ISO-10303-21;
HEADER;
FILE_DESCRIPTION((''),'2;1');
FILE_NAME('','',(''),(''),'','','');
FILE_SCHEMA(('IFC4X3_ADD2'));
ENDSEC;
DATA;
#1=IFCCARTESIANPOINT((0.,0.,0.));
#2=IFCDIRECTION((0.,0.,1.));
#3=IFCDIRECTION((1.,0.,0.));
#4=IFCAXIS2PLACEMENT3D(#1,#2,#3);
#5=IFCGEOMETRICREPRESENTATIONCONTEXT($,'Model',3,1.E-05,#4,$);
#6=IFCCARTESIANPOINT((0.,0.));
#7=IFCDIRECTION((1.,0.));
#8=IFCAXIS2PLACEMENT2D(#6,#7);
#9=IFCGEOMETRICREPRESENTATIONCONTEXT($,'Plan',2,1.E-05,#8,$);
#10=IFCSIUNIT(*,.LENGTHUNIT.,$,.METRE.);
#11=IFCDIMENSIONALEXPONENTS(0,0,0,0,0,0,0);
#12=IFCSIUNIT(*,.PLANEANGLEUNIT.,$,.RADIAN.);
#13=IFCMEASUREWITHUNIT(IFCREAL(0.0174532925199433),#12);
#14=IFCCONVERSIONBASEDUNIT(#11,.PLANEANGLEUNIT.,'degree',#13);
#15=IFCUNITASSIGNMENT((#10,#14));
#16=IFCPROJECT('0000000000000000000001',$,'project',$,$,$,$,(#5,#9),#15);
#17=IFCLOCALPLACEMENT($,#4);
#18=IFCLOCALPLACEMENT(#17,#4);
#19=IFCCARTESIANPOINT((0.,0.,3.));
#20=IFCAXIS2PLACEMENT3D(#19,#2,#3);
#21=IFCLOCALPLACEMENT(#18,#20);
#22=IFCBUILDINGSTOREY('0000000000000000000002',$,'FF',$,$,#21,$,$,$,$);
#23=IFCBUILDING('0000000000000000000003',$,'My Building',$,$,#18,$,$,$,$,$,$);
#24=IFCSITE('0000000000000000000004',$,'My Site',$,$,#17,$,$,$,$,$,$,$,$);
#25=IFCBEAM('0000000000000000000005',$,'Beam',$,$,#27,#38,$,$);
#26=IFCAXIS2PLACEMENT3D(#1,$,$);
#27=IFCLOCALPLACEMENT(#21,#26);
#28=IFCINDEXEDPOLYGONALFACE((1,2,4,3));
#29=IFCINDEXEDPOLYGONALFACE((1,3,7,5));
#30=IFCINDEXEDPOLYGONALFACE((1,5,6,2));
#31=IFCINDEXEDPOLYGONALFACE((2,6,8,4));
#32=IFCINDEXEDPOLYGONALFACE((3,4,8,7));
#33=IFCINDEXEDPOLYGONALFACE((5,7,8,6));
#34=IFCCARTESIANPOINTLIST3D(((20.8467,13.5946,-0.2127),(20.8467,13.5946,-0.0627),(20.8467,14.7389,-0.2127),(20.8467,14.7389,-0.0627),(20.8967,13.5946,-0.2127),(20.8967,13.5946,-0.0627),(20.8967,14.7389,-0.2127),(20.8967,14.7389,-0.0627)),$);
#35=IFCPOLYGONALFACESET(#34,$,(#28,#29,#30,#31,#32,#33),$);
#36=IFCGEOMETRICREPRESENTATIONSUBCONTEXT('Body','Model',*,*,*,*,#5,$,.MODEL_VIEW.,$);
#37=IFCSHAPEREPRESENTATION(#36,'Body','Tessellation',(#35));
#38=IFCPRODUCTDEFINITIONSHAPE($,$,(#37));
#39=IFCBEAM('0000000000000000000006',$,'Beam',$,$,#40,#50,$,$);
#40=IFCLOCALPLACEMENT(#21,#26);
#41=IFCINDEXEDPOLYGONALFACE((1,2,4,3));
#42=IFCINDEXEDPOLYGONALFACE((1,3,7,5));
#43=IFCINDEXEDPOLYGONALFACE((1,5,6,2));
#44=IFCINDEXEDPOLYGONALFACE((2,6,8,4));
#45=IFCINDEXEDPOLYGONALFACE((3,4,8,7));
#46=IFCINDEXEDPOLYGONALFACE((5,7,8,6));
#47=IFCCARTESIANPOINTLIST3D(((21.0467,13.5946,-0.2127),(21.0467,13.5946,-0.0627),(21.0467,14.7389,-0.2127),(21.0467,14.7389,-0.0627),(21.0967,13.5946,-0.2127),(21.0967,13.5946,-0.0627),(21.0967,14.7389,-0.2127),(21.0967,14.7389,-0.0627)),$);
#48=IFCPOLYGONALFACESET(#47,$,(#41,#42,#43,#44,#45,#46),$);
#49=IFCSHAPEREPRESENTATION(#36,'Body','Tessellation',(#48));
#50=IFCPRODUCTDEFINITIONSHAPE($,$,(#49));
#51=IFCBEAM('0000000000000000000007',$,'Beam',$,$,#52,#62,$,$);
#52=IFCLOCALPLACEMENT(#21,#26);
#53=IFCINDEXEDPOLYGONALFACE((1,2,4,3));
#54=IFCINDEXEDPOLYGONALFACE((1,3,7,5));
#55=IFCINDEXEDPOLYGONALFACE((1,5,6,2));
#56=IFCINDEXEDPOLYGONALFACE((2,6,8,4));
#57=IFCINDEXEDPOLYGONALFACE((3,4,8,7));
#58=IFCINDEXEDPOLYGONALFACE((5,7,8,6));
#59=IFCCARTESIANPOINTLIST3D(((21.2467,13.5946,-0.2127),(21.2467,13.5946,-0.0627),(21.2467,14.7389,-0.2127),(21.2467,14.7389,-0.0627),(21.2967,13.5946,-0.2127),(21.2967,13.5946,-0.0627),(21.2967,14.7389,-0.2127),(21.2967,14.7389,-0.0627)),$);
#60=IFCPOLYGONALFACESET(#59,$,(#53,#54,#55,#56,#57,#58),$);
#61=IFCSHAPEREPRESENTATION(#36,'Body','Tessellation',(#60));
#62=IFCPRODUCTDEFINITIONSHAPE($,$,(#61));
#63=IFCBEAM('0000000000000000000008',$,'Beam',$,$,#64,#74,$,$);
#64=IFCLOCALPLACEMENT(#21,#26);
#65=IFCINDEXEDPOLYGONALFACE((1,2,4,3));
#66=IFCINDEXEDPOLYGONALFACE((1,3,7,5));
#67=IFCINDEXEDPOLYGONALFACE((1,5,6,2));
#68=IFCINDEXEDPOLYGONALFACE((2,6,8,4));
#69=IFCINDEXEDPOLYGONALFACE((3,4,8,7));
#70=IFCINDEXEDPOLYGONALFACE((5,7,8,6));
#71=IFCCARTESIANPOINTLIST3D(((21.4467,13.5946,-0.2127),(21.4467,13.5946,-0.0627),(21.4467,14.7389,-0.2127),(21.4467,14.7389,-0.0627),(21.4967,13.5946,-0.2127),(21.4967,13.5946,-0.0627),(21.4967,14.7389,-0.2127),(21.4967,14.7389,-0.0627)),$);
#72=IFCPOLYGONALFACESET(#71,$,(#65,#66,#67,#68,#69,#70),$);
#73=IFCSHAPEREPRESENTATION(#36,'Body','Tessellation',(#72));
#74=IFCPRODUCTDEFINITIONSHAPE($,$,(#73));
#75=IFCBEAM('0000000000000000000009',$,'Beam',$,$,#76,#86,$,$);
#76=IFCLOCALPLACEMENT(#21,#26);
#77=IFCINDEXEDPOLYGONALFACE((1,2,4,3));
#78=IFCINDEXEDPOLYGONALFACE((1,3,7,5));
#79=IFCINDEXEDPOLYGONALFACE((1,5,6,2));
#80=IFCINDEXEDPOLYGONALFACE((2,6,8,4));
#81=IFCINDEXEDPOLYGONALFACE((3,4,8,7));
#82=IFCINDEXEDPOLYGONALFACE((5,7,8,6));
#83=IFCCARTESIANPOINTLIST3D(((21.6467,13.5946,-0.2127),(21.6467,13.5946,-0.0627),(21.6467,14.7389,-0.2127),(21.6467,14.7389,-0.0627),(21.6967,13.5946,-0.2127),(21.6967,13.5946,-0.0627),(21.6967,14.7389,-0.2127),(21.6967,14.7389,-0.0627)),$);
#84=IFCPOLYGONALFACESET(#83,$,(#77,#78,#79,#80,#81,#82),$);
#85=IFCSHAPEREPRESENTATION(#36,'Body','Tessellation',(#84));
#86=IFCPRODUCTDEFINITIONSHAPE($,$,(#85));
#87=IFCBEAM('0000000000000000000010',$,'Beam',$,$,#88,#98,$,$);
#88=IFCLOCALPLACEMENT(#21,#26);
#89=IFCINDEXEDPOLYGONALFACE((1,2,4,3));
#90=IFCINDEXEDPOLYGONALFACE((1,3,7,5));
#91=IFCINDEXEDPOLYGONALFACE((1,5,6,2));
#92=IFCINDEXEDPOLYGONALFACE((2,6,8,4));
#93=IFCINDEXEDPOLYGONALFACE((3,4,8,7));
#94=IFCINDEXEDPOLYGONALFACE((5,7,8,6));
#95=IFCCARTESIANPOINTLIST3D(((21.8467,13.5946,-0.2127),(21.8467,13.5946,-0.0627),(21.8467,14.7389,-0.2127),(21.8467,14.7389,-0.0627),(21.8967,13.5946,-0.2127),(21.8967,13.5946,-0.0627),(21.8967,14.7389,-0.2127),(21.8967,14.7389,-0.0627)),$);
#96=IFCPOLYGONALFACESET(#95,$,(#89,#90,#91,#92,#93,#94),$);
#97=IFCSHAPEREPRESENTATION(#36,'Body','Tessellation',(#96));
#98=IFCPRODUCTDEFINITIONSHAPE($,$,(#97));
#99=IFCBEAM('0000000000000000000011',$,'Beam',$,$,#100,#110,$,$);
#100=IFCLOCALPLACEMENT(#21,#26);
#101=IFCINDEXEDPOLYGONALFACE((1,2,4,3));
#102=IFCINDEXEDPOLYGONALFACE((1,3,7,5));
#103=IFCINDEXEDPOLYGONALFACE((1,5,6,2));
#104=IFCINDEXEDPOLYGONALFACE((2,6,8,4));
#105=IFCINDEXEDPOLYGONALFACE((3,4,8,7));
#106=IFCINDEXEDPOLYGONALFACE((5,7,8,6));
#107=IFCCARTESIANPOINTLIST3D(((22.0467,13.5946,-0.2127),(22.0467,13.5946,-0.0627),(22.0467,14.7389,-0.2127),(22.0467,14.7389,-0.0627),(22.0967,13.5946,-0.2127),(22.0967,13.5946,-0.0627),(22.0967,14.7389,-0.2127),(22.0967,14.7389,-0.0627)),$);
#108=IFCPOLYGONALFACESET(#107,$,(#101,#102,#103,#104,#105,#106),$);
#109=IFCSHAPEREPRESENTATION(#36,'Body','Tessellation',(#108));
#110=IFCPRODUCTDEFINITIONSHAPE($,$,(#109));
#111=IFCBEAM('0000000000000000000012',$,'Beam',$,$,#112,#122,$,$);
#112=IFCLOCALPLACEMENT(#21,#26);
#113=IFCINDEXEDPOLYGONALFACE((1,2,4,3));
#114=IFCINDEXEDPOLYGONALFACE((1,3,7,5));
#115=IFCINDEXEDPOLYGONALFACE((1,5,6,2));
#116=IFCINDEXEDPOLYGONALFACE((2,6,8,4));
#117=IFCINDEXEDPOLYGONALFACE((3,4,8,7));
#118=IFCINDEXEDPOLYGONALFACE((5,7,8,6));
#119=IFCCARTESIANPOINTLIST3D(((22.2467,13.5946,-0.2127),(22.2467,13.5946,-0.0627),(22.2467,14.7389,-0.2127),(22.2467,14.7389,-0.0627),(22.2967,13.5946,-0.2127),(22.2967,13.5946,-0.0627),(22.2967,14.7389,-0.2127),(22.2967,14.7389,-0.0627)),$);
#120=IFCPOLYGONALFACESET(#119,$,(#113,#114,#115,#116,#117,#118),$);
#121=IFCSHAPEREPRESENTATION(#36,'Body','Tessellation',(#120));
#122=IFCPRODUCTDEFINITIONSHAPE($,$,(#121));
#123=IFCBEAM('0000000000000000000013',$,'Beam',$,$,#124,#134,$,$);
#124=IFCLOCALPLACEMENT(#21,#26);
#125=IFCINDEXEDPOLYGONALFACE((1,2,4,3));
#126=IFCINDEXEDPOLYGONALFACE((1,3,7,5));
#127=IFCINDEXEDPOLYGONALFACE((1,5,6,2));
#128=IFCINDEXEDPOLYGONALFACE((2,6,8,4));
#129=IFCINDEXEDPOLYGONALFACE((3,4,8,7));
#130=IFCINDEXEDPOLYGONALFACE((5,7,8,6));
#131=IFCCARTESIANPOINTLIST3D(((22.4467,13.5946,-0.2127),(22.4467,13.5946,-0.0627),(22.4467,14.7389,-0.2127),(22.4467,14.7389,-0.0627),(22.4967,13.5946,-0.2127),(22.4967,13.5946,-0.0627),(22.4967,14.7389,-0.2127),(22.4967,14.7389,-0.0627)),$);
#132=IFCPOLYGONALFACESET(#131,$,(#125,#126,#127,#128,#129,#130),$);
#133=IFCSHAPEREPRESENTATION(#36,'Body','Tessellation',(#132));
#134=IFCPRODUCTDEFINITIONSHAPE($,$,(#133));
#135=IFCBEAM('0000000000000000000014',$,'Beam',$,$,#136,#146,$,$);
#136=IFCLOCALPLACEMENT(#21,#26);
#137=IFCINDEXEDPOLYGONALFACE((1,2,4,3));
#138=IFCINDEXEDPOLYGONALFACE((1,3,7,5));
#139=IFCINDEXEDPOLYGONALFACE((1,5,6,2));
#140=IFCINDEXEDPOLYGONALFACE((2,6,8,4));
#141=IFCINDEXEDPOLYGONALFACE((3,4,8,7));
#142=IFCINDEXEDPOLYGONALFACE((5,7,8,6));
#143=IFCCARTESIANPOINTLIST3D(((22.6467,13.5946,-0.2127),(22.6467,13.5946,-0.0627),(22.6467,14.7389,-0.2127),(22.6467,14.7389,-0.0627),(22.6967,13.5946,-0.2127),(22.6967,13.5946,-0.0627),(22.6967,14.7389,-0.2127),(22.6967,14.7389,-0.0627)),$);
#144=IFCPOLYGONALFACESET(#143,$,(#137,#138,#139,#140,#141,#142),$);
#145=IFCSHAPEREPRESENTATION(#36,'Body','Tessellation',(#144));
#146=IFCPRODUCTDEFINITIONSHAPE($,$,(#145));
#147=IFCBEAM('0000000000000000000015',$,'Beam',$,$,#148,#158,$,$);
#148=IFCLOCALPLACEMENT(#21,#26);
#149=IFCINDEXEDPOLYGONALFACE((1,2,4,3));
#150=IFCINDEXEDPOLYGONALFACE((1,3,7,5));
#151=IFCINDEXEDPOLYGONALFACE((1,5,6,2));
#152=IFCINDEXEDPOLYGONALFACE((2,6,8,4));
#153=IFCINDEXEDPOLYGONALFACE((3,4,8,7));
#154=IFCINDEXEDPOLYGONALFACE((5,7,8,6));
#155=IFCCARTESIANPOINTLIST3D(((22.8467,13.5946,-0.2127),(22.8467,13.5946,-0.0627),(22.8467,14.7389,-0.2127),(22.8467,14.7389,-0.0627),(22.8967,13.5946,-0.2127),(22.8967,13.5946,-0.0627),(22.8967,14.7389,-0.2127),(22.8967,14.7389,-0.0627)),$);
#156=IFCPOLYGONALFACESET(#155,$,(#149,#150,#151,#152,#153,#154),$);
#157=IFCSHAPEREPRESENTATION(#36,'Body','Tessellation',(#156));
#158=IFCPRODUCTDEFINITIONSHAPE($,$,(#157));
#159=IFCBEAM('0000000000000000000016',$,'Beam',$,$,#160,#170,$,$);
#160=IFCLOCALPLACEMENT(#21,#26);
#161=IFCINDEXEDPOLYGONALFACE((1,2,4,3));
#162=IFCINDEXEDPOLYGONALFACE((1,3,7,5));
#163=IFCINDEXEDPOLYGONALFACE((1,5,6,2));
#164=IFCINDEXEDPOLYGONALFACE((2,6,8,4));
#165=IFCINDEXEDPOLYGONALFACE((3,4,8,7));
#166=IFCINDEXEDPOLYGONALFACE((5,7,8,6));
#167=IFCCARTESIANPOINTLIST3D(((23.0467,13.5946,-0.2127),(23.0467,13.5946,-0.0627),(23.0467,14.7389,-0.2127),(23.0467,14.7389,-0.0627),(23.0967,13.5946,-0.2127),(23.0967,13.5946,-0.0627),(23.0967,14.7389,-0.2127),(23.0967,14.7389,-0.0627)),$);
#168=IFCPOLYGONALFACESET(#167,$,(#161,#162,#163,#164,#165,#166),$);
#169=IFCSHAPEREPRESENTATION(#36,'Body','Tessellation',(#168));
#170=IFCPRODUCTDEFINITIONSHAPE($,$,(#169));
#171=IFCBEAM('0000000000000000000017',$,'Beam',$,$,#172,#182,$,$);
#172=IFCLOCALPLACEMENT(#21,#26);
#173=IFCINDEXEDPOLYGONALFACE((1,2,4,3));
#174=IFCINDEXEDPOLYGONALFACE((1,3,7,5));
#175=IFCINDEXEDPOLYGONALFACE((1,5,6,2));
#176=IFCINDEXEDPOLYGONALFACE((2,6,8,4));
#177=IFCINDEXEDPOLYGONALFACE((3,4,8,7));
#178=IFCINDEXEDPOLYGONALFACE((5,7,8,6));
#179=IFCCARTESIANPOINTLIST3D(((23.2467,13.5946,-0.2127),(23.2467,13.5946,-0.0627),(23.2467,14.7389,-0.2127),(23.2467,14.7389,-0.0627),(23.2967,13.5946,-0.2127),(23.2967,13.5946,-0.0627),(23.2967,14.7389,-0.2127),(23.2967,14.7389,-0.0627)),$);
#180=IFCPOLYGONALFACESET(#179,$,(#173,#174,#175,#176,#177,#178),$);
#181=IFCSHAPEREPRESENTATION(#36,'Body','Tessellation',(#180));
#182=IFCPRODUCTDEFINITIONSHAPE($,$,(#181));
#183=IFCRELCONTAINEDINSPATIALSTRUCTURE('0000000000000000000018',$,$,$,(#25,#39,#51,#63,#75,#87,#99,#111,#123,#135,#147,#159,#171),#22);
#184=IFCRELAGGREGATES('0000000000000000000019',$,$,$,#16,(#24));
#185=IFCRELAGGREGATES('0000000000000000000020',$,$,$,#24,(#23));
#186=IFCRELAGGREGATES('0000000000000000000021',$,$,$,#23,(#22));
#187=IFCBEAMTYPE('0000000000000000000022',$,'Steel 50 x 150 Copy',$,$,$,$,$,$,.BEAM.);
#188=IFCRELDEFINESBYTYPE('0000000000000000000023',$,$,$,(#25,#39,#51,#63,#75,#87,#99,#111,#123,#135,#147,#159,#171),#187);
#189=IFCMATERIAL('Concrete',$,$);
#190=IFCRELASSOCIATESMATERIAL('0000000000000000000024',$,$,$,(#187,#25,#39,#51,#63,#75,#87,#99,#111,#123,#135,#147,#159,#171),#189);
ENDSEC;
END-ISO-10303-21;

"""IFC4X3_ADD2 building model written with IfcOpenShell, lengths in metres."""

from ifc_helpers import new_model, entity, si_unit, converted_unit, frame, origin_with_axes, origin_2d_with_axis, place, context, subcontext, project, spatial, rectangle, extrude, material, material_profile, profile_set, profile_usage, type_object, element, save


model = new_model("IFC4X3_ADD2")

# Units and contexts
model_context = context("Model", 3, precision=1e-05, world=origin_with_axes())
plan_context = context("Plan", 2, precision=1e-05, world=origin_2d_with_axis())
body_context = subcontext(model_context, "Body", "Model", "MODEL_VIEW")
ifc_project = project(units=[si_unit("LENGTHUNIT", "METRE"), converted_unit("PLANEANGLEUNIT", "degree", entity("IfcReal", 0.0174532925199433), si_unit("PLANEANGLEUNIT", "RADIAN"), dimensions=[0, 0, 0, 0, 0, 0, 0])], contexts=[model_context, plan_context])

# Site, building, storey
site_placement = place(None, origin_with_axes())
site = spatial("IfcSite", under=ifc_project, at=site_placement, Name="My Site")
building_placement = place(site_placement, origin_with_axes())
building = spatial("IfcBuilding", under=site, at=building_placement, Name="My Building")
storey_placement = place(building_placement, frame((0.0, 0.0, 3.0), z_axis=(0.0, 0.0, 1.0), x_axis=(1.0, 0.0, 0.0)))
storey = spatial("IfcBuildingStorey", under=building, at=storey_placement, Name="FF")

# Beams
ifc_material = material(Name="Concrete")
ifc_material_profile_1 = material_profile(ifc_material, rectangle(XDim=0.05, YDim=0.15))
ifc_profile_set_1 = profile_set([ifc_material_profile_1])
beam_type_1 = type_object("IfcBeamType", Name="Steel 50 x 150 Copy", PredefinedType="BEAM", material=ifc_profile_set_1)
ifc_profile_usage_1 = profile_usage(ifc_profile_set_1)
beam_1_placement = place(storey_placement, frame((20.8717, 14.7389, -0.1377), z_axis=(0.0, -1.0, 0.0), x_axis=(1.0, 0.0, 0.0)))
element("IfcBeam", 1, at=beam_1_placement, inside=storey, type_object=beam_type_1, material=ifc_profile_usage_1, Name="Beam", context=body_context, shape_type="SweptSolid", body=[
    extrude(rectangle(XDim=0.05, YDim=0.15), origin_with_axes(), (0.0, 0.0, 1.0), 1.1444),
])
ifc_profile_usage_2 = profile_usage(ifc_profile_set_1)
beam_2_placement = place(storey_placement, frame((21.0717, 14.7389, -0.1377), z_axis=(0.0, -1.0, 0.0), x_axis=(1.0, 0.0, 0.0)))
element("IfcBeam", 2, at=beam_2_placement, inside=storey, type_object=beam_type_1, material=ifc_profile_usage_2, Name="Beam", context=body_context, shape_type="SweptSolid", body=[
    extrude(rectangle(XDim=0.05, YDim=0.15), origin_with_axes(), (0.0, 0.0, 1.0), 1.1444),
])
ifc_profile_usage_3 = profile_usage(ifc_profile_set_1)
beam_3_placement = place(storey_placement, frame((21.2717, 14.7389, -0.1377), z_axis=(0.0, -1.0, 0.0), x_axis=(1.0, 0.0, 0.0)))
element("IfcBeam", 3, at=beam_3_placement, inside=storey, type_object=beam_type_1, material=ifc_profile_usage_3, Name="Beam", context=body_context, shape_type="SweptSolid", body=[
    extrude(rectangle(XDim=0.05, YDim=0.15), origin_with_axes(), (0.0, 0.0, 1.0), 1.1444),
])
ifc_profile_usage_4 = profile_usage(ifc_profile_set_1)
beam_4_placement = place(storey_placement, frame((21.4717, 14.7389, -0.1377), z_axis=(0.0, -1.0, 0.0), x_axis=(1.0, 0.0, 0.0)))
element("IfcBeam", 4, at=beam_4_placement, inside=storey, type_object=beam_type_1, material=ifc_profile_usage_4, Name="Beam", context=body_context, shape_type="SweptSolid", body=[
    extrude(rectangle(XDim=0.05, YDim=0.15), origin_with_axes(), (0.0, 0.0, 1.0), 1.1444),
])
ifc_profile_usage_5 = profile_usage(ifc_profile_set_1)
beam_5_placement = place(storey_placement, frame((21.6717, 14.7389, -0.1377), z_axis=(0.0, -1.0, 0.0), x_axis=(1.0, 0.0, 0.0)))
element("IfcBeam", 5, at=beam_5_placement, inside=storey, type_object=beam_type_1, material=ifc_profile_usage_5, Name="Beam", context=body_context, shape_type="SweptSolid", body=[
    extrude(rectangle(XDim=0.05, YDim=0.15), origin_with_axes(), (0.0, 0.0, 1.0), 1.1444),
])
ifc_profile_usage_6 = profile_usage(ifc_profile_set_1)
beam_6_placement = place(storey_placement, frame((21.8717, 14.7389, -0.1377), z_axis=(0.0, -1.0, 0.0), x_axis=(1.0, 0.0, 0.0)))
element("IfcBeam", 6, at=beam_6_placement, inside=storey, type_object=beam_type_1, material=ifc_profile_usage_6, Name="Beam", context=body_context, shape_type="SweptSolid", body=[
    extrude(rectangle(XDim=0.05, YDim=0.15), origin_with_axes(), (0.0, 0.0, 1.0), 1.1444),
])
ifc_profile_usage_7 = profile_usage(ifc_profile_set_1)
beam_7_placement = place(storey_placement, frame((22.0717, 14.7389, -0.1377), z_axis=(0.0, -1.0, 0.0), x_axis=(1.0, 0.0, 0.0)))
element("IfcBeam", 7, at=beam_7_placement, inside=storey, type_object=beam_type_1, material=ifc_profile_usage_7, Name="Beam", context=body_context, shape_type="SweptSolid", body=[
    extrude(rectangle(XDim=0.05, YDim=0.15), origin_with_axes(), (0.0, 0.0, 1.0), 1.1444),
])
ifc_profile_usage_8 = profile_usage(ifc_profile_set_1)
beam_8_placement = place(storey_placement, frame((22.2717, 14.7389, -0.1377), z_axis=(0.0, -1.0, 0.0), x_axis=(1.0, 0.0, 0.0)))
element("IfcBeam", 8, at=beam_8_placement, inside=storey, type_object=beam_type_1, material=ifc_profile_usage_8, Name="Beam", context=body_context, shape_type="SweptSolid", body=[
    extrude(rectangle(XDim=0.05, YDim=0.15), origin_with_axes(), (0.0, 0.0, 1.0), 1.1444),
])
ifc_profile_usage_9 = profile_usage(ifc_profile_set_1)
beam_9_placement = place(storey_placement, frame((22.4717, 14.7389, -0.1377), z_axis=(0.0, -1.0, 0.0), x_axis=(1.0, 0.0, 0.0)))
element("IfcBeam", 9, at=beam_9_placement, inside=storey, type_object=beam_type_1, material=ifc_profile_usage_9, Name="Beam", context=body_context, shape_type="SweptSolid", body=[
    extrude(rectangle(XDim=0.05, YDim=0.15), origin_with_axes(), (0.0, 0.0, 1.0), 1.1444),
])
ifc_profile_usage_10 = profile_usage(ifc_profile_set_1)
beam_10_placement = place(storey_placement, frame((22.6717, 14.7389, -0.1377), z_axis=(0.0, -1.0, 0.0), x_axis=(1.0, 0.0, 0.0)))
element("IfcBeam", 10, at=beam_10_placement, inside=storey, type_object=beam_type_1, material=ifc_profile_usage_10, Name="Beam", context=body_context, shape_type="SweptSolid", body=[
    extrude(rectangle(XDim=0.05, YDim=0.15), origin_with_axes(), (0.0, 0.0, 1.0), 1.1444),
])
ifc_profile_usage_11 = profile_usage(ifc_profile_set_1)
beam_11_placement = place(storey_placement, frame((22.8717, 14.7389, -0.1377), z_axis=(0.0, -1.0, 0.0), x_axis=(1.0, 0.0, 0.0)))
element("IfcBeam", 11, at=beam_11_placement, inside=storey, type_object=beam_type_1, material=ifc_profile_usage_11, Name="Beam", context=body_context, shape_type="SweptSolid", body=[
    extrude(rectangle(XDim=0.05, YDim=0.15), origin_with_axes(), (0.0, 0.0, 1.0), 1.1444),
])
ifc_profile_usage_12 = profile_usage(ifc_profile_set_1)
beam_12_placement = place(storey_placement, frame((23.0717, 14.7389, -0.1377), z_axis=(0.0, -1.0, 0.0), x_axis=(1.0, 0.0, 0.0)))
element("IfcBeam", 12, at=beam_12_placement, inside=storey, type_object=beam_type_1, material=ifc_profile_usage_12, Name="Beam", context=body_context, shape_type="SweptSolid", body=[
    extrude(rectangle(XDim=0.05, YDim=0.15), origin_with_axes(), (0.0, 0.0, 1.0), 1.1444),
])
ifc_profile_usage_13 = profile_usage(ifc_profile_set_1)
beam_13_placement = place(storey_placement, frame((23.2717, 14.7389, -0.1377), z_axis=(0.0, -1.0, 0.0), x_axis=(1.0, 0.0, 0.0)))
element("IfcBeam", 13, at=beam_13_placement, inside=storey, type_object=beam_type_1, material=ifc_profile_usage_13, Name="Beam", context=body_context, shape_type="SweptSolid", body=[
    extrude(rectangle(XDim=0.05, YDim=0.15), origin_with_axes(), (0.0, 0.0, 1.0), 1.1444),
])

save(model, "model.ifc")
